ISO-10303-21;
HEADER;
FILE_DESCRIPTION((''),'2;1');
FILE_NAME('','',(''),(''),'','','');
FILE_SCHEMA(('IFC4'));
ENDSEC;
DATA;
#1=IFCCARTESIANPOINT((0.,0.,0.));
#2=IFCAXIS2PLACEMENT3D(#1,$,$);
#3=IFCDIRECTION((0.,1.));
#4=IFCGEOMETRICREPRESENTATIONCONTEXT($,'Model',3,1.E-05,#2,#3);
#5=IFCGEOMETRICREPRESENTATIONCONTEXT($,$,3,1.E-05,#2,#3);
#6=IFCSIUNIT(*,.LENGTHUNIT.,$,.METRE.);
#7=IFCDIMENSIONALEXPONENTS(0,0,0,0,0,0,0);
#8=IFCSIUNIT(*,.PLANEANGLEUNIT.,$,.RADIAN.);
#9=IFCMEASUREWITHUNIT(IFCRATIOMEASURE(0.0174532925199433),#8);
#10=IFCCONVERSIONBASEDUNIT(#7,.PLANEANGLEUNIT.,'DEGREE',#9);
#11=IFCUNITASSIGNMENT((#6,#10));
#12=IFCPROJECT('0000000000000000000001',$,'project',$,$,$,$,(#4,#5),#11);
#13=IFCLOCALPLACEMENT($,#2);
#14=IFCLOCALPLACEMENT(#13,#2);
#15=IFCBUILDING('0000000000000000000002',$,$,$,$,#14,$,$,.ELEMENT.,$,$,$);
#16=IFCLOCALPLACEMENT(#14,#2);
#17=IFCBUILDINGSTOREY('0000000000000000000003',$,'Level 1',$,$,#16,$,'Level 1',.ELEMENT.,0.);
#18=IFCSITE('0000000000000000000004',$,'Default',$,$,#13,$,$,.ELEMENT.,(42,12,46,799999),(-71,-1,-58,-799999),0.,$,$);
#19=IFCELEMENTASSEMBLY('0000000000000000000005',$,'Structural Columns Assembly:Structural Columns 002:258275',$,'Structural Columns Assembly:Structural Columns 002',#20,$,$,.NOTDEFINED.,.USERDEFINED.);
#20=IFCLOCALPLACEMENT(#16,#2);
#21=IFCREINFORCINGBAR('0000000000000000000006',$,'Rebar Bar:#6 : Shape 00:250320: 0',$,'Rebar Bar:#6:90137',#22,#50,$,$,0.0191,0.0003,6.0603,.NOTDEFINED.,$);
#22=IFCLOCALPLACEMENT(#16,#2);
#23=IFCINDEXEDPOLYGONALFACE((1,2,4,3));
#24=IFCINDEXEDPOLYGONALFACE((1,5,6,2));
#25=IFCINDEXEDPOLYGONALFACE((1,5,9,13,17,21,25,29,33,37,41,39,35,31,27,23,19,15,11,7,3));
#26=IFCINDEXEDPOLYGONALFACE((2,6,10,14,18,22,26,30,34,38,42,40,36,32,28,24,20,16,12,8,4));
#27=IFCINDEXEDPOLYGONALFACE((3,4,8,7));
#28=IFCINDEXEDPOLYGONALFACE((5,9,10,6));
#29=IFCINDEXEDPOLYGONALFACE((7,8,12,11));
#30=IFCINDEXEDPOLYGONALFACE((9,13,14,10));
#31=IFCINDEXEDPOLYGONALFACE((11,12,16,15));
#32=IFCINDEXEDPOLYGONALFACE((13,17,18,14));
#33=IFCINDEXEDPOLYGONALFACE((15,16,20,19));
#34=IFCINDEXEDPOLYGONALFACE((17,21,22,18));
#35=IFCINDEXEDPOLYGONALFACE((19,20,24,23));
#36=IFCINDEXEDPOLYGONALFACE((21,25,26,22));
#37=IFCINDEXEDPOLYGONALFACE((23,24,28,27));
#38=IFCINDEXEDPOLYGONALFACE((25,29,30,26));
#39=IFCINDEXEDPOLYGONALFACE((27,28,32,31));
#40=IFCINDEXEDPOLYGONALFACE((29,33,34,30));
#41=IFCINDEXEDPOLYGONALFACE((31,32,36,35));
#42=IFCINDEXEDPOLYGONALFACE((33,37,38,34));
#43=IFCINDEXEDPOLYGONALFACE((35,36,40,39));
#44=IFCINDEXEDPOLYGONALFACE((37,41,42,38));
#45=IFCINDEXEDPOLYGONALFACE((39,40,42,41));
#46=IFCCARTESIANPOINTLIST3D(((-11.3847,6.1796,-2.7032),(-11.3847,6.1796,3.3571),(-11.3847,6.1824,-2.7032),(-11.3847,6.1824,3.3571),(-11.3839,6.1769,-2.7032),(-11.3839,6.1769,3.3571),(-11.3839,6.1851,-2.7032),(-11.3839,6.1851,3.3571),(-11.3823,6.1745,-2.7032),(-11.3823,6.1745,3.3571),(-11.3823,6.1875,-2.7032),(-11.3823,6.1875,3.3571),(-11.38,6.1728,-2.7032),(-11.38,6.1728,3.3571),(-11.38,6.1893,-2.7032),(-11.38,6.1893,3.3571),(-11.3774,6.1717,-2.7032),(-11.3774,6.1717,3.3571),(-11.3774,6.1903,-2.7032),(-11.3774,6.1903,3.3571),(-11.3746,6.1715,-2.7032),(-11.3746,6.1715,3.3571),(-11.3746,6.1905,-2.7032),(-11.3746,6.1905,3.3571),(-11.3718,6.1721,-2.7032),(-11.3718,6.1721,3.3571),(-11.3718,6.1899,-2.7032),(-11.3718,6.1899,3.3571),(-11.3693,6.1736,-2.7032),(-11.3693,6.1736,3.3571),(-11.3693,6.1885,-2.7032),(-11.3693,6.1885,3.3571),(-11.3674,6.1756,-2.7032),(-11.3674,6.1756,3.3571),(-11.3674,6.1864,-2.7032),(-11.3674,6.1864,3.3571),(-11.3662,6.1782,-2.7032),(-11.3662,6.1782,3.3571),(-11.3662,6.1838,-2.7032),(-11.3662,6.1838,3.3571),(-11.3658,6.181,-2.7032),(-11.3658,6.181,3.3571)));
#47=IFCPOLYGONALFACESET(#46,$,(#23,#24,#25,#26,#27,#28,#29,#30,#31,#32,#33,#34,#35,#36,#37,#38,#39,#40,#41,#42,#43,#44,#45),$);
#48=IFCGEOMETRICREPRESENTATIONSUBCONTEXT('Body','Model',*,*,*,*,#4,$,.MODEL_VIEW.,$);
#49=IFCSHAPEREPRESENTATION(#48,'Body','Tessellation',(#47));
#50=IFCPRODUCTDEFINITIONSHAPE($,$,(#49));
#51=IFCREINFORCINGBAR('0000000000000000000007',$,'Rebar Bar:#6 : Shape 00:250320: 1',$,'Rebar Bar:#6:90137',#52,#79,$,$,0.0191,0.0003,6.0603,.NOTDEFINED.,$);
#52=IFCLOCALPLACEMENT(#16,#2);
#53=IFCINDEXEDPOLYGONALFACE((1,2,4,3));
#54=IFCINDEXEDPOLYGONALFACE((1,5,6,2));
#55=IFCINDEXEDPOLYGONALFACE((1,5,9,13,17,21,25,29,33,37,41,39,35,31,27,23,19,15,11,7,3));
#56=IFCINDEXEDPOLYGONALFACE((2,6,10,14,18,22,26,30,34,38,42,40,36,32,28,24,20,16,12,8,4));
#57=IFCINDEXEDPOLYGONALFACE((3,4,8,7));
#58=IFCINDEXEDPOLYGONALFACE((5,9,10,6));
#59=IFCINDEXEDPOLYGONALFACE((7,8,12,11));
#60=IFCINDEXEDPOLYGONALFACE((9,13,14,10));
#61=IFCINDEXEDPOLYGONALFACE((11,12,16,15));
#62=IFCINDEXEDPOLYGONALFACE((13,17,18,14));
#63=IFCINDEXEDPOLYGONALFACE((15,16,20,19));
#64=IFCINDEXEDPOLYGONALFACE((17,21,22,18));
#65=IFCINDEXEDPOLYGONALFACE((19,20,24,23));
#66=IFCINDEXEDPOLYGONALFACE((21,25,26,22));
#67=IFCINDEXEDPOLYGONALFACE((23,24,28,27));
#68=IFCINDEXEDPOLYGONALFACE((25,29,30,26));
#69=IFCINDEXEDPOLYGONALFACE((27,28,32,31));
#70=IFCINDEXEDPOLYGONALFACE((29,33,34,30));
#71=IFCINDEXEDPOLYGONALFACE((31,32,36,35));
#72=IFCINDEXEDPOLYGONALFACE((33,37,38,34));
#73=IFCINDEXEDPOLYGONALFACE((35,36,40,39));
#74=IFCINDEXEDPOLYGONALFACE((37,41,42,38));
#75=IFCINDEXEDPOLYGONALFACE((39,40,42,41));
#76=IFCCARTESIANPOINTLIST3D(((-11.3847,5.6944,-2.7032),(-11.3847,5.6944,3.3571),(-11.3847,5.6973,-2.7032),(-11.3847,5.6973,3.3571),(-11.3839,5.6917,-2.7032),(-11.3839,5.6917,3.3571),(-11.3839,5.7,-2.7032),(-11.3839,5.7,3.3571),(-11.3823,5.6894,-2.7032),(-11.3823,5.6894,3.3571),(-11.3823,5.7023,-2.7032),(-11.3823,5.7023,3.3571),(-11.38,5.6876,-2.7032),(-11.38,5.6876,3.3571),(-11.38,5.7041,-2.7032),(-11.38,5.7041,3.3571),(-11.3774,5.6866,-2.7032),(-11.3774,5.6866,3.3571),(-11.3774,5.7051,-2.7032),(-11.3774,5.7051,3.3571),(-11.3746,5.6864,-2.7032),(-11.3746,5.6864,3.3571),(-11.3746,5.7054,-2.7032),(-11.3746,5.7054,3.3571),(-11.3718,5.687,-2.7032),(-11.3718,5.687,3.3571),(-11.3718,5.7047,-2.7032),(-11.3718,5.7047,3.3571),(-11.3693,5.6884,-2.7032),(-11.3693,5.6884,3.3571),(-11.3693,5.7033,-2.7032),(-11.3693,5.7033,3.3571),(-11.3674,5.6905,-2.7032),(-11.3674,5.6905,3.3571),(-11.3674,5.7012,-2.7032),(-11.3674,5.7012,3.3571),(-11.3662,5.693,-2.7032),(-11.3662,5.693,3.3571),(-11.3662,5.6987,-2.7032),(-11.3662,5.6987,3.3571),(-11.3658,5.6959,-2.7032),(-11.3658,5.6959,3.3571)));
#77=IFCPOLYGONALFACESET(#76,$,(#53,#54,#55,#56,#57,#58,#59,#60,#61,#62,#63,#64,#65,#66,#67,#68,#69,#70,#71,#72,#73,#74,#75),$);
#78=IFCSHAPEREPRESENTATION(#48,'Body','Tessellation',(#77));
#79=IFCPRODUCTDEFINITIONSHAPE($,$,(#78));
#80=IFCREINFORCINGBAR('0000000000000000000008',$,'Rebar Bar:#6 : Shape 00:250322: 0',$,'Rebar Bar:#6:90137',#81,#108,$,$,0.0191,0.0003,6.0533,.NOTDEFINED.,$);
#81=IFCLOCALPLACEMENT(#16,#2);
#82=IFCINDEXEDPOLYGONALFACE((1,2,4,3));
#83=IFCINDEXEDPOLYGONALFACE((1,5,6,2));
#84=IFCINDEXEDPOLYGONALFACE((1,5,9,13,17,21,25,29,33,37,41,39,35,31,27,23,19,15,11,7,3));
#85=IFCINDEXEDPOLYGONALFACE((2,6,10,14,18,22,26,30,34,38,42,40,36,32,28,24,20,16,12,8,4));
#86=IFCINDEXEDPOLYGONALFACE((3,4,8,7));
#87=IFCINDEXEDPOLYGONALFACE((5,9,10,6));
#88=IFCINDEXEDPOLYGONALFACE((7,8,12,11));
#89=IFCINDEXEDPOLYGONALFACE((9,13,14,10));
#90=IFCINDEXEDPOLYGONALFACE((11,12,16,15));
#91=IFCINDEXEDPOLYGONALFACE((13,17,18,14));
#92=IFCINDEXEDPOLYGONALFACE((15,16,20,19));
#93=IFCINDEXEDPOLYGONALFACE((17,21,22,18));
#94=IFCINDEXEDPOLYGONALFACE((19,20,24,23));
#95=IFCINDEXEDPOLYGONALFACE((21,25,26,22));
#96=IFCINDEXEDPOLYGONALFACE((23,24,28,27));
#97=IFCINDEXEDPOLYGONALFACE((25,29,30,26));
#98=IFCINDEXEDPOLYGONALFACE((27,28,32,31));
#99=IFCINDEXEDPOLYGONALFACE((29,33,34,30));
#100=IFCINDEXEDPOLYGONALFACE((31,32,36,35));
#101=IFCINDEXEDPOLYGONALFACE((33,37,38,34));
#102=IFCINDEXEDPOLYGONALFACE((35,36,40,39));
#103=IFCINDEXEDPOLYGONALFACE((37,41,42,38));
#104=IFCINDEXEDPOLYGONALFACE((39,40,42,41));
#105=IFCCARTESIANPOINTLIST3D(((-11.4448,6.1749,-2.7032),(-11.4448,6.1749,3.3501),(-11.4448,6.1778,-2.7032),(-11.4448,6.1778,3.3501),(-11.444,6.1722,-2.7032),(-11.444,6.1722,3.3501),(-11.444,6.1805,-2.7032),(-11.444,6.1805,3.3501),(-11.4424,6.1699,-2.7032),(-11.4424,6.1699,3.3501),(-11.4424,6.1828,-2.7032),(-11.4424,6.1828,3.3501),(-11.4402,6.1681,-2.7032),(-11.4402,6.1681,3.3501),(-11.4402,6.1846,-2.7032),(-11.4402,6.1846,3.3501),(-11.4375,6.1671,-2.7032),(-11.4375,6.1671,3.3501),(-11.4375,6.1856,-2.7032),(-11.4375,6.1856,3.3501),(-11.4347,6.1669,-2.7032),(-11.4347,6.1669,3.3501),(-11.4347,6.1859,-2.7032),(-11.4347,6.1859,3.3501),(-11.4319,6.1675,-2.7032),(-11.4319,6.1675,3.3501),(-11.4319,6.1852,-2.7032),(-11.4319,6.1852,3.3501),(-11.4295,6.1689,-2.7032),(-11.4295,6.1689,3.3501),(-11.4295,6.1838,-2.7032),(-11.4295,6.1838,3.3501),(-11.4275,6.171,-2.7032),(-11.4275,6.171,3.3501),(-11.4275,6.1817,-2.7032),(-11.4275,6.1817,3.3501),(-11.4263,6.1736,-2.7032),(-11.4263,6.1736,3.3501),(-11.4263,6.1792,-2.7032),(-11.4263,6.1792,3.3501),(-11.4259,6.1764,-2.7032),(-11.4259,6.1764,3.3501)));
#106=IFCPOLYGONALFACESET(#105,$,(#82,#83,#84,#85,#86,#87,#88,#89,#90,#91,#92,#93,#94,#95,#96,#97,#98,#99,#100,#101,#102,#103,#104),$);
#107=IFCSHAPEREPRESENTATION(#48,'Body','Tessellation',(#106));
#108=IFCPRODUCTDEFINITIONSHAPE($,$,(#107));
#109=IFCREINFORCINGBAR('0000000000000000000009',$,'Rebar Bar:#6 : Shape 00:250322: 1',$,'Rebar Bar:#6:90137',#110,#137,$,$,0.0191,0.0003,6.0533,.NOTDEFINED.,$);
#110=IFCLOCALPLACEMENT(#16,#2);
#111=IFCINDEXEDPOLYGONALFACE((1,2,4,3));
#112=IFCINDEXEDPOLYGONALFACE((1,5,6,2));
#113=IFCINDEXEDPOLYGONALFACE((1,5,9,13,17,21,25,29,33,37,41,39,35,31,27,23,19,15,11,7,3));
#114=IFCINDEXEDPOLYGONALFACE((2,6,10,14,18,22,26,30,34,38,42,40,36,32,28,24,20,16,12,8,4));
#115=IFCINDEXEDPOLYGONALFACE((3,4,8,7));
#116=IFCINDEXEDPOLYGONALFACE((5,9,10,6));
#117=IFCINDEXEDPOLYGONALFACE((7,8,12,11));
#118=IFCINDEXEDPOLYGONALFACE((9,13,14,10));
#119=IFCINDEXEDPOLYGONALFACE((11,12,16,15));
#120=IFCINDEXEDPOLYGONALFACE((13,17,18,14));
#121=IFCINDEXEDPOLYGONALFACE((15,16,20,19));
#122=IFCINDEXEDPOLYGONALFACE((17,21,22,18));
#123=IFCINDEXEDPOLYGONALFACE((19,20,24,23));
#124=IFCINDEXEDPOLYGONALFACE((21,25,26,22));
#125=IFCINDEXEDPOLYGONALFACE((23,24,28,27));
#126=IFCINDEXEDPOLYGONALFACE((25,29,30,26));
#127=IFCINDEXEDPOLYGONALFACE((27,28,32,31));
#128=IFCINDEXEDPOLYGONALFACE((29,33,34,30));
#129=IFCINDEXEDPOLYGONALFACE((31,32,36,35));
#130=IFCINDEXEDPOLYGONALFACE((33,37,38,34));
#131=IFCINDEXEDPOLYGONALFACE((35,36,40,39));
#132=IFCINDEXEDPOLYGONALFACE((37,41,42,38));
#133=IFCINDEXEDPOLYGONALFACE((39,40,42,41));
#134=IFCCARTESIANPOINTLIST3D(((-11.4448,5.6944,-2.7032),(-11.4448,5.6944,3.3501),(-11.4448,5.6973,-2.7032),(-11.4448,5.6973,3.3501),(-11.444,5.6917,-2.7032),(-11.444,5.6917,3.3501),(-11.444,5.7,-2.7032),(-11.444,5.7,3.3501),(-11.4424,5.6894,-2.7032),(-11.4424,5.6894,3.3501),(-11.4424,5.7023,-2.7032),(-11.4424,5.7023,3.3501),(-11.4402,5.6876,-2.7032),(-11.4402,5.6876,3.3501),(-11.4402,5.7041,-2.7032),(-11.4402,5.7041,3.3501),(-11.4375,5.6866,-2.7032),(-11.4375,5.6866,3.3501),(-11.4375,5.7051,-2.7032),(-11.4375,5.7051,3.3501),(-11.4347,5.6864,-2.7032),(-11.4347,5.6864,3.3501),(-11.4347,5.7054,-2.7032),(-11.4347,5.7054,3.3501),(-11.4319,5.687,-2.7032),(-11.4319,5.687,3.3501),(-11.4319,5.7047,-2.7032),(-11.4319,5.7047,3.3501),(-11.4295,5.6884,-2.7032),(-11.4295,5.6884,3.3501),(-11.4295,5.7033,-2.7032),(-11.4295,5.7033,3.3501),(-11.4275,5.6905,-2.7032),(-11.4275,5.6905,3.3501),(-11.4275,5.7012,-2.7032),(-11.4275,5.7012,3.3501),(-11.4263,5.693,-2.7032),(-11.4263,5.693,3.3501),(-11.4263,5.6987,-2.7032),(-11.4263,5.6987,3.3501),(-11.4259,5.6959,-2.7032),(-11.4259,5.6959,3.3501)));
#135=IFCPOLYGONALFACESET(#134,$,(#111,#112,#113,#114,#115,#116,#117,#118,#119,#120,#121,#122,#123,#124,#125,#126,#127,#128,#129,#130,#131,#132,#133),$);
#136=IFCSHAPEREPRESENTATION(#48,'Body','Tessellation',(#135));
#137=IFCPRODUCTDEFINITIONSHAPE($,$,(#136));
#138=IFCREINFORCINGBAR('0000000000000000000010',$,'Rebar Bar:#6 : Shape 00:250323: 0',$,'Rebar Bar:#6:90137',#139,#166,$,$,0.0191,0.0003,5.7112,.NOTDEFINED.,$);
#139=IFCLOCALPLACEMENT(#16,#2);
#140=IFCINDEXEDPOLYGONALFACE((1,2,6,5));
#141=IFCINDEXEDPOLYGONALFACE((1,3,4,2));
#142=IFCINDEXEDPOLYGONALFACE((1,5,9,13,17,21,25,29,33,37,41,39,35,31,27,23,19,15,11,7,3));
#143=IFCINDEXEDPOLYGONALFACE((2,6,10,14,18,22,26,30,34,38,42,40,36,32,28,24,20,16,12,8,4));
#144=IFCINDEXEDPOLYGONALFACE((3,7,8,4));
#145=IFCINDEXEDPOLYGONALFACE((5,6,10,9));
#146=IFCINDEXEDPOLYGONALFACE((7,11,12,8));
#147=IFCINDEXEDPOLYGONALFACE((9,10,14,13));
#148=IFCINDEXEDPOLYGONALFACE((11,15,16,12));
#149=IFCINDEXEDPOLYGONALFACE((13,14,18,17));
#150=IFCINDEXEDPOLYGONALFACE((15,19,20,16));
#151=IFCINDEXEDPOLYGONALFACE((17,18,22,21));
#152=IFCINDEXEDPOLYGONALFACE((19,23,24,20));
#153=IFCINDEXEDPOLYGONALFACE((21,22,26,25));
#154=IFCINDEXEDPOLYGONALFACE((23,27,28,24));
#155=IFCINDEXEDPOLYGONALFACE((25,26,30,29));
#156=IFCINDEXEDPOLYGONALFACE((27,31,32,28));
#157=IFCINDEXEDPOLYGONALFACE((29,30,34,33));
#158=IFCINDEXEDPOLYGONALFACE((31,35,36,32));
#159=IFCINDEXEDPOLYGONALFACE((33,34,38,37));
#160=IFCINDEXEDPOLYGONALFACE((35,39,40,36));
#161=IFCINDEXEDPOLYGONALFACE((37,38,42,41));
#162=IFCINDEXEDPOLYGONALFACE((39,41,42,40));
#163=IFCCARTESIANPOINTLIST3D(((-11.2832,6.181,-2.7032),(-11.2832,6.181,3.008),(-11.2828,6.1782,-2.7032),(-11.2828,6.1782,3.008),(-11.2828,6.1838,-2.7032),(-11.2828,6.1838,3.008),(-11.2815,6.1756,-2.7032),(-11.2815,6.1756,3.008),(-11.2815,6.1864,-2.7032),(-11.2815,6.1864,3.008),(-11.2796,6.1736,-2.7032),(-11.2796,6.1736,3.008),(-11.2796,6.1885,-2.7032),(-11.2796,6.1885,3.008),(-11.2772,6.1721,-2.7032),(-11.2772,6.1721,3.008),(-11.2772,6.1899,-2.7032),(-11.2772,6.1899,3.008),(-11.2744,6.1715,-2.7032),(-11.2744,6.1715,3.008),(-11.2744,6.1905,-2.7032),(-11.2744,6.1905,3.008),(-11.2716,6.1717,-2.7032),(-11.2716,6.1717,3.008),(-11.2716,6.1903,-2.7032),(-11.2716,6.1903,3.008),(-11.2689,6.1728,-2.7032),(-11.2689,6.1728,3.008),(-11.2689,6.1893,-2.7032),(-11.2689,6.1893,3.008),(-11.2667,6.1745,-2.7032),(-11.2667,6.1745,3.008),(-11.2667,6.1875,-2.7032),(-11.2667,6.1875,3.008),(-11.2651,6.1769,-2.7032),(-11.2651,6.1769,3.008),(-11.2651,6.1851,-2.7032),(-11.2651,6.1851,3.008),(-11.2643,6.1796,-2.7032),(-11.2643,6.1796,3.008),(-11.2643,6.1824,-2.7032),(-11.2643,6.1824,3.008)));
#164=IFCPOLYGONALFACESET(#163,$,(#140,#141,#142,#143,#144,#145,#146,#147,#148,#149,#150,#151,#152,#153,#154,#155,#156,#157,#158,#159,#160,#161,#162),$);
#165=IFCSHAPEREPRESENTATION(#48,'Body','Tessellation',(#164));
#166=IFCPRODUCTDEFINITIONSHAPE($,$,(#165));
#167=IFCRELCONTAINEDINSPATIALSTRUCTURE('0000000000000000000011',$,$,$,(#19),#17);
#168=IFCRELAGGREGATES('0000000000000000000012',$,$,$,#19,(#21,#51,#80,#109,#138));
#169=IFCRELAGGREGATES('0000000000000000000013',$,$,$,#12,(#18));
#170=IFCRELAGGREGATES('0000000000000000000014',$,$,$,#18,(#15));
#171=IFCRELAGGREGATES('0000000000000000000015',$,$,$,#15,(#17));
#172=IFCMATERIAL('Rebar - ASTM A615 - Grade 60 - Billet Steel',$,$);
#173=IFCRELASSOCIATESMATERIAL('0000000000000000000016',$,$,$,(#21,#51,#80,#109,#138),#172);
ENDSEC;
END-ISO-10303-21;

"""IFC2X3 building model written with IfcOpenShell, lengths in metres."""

from ifc_helpers import new_model, entity, si_unit, converted_unit, direction, origin, place, context, subcontext, project, spatial, material, element, aggregate, save


model = new_model("IFC2X3")

# Units and contexts
model_context = context("Model", 3, precision=1e-05, world=origin(), true_north=direction((0.0, 1.0)))
context_of_model = context(None, 3, precision=1e-05, world=origin(), true_north=direction((0.0, 1.0)))
body_context = subcontext(model_context, "Body", "Model", "MODEL_VIEW")
ifc_project = project(units=[si_unit("LENGTHUNIT", "METRE"), converted_unit("PLANEANGLEUNIT", "DEGREE", entity("IfcRatioMeasure", 0.0174532925199433), si_unit("PLANEANGLEUNIT", "RADIAN"), dimensions=[0, 0, 0, 0, 0, 0, 0])], contexts=[model_context, context_of_model])

# Site, building, storey
site_placement = place(None, origin())
site = spatial("IfcSite", under=ifc_project, at=site_placement, Name="Default", CompositionType="ELEMENT", RefLatitude=(42, 12, 46, 799999), RefLongitude=(-71, -1, -58, -799999), RefElevation=0.0)
building_placement = place(site_placement, origin())
building = spatial("IfcBuilding", under=site, at=building_placement, CompositionType="ELEMENT")
storey_placement = place(building_placement, origin())
storey = spatial("IfcBuildingStorey", under=building, at=storey_placement, Name="Level 1", LongName="Level 1", CompositionType="ELEMENT", Elevation=0.0)

# Element assembly, reinforcing bars
assembly_1_placement = place(storey_placement, origin())
assembly_1 = element("IfcElementAssembly", 1, at=assembly_1_placement, inside=storey, Name="Structural Columns Assembly:Structural Columns 002:258275", ObjectType="Structural Columns Assembly:Structural Columns 002", AssemblyPlace="NOTDEFINED", PredefinedType="USERDEFINED")
ifc_material_1 = material(Name="Rebar - ASTM A615 - Grade 60 - Billet Steel")
reinforcing_bar_1_placement = place(assembly_1_placement, origin())
reinforcing_bar_1 = element("IfcReinforcingBar", 2, at=reinforcing_bar_1_placement, material=ifc_material_1, Name="Rebar Bar:#6 : Shape 00:250320: 0", ObjectType="Rebar Bar:#6:90137", BarLength=6.0603, BarRole="NOTDEFINED", CrossSectionArea=0.0003, NominalDiameter=0.0191, context=body_context, shape_type="AdvancedSweptSolid", body=[
    entity("IfcSweptDiskSolid", entity("IfcCompositeCurve", [entity("IfcCompositeCurveSegment", "CONTINUOUS", True, entity("IfcPolyline", [entity("IfcCartesianPoint", [-11.3753, 6.181, -2.7032]), entity("IfcCartesianPoint", [-11.3753, 6.181, 3.3571])]))], False), 0.0095, None, 0.0, 1.0),
])
reinforcing_bar_2_placement = place(assembly_1_placement, origin())
reinforcing_bar_2 = element("IfcReinforcingBar", 3, at=reinforcing_bar_2_placement, material=ifc_material_1, Name="Rebar Bar:#6 : Shape 00:250320: 1", ObjectType="Rebar Bar:#6:90137", BarLength=6.0603, BarRole="NOTDEFINED", CrossSectionArea=0.0003, NominalDiameter=0.0191, context=body_context, shape_type="AdvancedSweptSolid", body=[
    entity("IfcSweptDiskSolid", entity("IfcCompositeCurve", [entity("IfcCompositeCurveSegment", "CONTINUOUS", True, entity("IfcPolyline", [entity("IfcCartesianPoint", [-11.3753, 5.6959, -2.7032]), entity("IfcCartesianPoint", [-11.3753, 5.6959, 3.3571])]))], False), 0.0095, None, 0.0, 1.0),
])
reinforcing_bar_3_placement = place(assembly_1_placement, origin())
reinforcing_bar_3 = element("IfcReinforcingBar", 4, at=reinforcing_bar_3_placement, material=ifc_material_1, Name="Rebar Bar:#6 : Shape 00:250322: 0", ObjectType="Rebar Bar:#6:90137", BarLength=6.0533, BarRole="NOTDEFINED", CrossSectionArea=0.0003, NominalDiameter=0.0191, context=body_context, shape_type="AdvancedSweptSolid", body=[
    entity("IfcSweptDiskSolid", entity("IfcCompositeCurve", [entity("IfcCompositeCurveSegment", "CONTINUOUS", True, entity("IfcPolyline", [entity("IfcCartesianPoint", [-11.4354, 6.1764, -2.7032]), entity("IfcCartesianPoint", [-11.4354, 6.1764, 3.3501])]))], False), 0.0095, None, 0.0, 1.0),
])
reinforcing_bar_4_placement = place(assembly_1_placement, origin())
reinforcing_bar_4 = element("IfcReinforcingBar", 5, at=reinforcing_bar_4_placement, material=ifc_material_1, Name="Rebar Bar:#6 : Shape 00:250322: 1", ObjectType="Rebar Bar:#6:90137", BarLength=6.0533, BarRole="NOTDEFINED", CrossSectionArea=0.0003, NominalDiameter=0.0191, context=body_context, shape_type="AdvancedSweptSolid", body=[
    entity("IfcSweptDiskSolid", entity("IfcCompositeCurve", [entity("IfcCompositeCurveSegment", "CONTINUOUS", True, entity("IfcPolyline", [entity("IfcCartesianPoint", [-11.4354, 5.6959, -2.7032]), entity("IfcCartesianPoint", [-11.4354, 5.6959, 3.3501])]))], False), 0.0095, None, 0.0, 1.0),
])
reinforcing_bar_5_placement = place(assembly_1_placement, origin())
reinforcing_bar_5 = element("IfcReinforcingBar", 6, at=reinforcing_bar_5_placement, material=ifc_material_1, Name="Rebar Bar:#6 : Shape 00:250323: 0", ObjectType="Rebar Bar:#6:90137", BarLength=5.7112, BarRole="NOTDEFINED", CrossSectionArea=0.0003, NominalDiameter=0.0191, context=body_context, shape_type="AdvancedSweptSolid", body=[
    entity("IfcSweptDiskSolid", entity("IfcCompositeCurve", [entity("IfcCompositeCurveSegment", "CONTINUOUS", True, entity("IfcPolyline", [entity("IfcCartesianPoint", [-11.2737, 6.181, 3.008]), entity("IfcCartesianPoint", [-11.2737, 6.181, -2.7032])]))], False), 0.0095, None, 0.0, 1.0),
])
aggregate(assembly_1, [reinforcing_bar_1, reinforcing_bar_2, reinforcing_bar_3, reinforcing_bar_4, reinforcing_bar_5])

save(model, "model.ifc")
